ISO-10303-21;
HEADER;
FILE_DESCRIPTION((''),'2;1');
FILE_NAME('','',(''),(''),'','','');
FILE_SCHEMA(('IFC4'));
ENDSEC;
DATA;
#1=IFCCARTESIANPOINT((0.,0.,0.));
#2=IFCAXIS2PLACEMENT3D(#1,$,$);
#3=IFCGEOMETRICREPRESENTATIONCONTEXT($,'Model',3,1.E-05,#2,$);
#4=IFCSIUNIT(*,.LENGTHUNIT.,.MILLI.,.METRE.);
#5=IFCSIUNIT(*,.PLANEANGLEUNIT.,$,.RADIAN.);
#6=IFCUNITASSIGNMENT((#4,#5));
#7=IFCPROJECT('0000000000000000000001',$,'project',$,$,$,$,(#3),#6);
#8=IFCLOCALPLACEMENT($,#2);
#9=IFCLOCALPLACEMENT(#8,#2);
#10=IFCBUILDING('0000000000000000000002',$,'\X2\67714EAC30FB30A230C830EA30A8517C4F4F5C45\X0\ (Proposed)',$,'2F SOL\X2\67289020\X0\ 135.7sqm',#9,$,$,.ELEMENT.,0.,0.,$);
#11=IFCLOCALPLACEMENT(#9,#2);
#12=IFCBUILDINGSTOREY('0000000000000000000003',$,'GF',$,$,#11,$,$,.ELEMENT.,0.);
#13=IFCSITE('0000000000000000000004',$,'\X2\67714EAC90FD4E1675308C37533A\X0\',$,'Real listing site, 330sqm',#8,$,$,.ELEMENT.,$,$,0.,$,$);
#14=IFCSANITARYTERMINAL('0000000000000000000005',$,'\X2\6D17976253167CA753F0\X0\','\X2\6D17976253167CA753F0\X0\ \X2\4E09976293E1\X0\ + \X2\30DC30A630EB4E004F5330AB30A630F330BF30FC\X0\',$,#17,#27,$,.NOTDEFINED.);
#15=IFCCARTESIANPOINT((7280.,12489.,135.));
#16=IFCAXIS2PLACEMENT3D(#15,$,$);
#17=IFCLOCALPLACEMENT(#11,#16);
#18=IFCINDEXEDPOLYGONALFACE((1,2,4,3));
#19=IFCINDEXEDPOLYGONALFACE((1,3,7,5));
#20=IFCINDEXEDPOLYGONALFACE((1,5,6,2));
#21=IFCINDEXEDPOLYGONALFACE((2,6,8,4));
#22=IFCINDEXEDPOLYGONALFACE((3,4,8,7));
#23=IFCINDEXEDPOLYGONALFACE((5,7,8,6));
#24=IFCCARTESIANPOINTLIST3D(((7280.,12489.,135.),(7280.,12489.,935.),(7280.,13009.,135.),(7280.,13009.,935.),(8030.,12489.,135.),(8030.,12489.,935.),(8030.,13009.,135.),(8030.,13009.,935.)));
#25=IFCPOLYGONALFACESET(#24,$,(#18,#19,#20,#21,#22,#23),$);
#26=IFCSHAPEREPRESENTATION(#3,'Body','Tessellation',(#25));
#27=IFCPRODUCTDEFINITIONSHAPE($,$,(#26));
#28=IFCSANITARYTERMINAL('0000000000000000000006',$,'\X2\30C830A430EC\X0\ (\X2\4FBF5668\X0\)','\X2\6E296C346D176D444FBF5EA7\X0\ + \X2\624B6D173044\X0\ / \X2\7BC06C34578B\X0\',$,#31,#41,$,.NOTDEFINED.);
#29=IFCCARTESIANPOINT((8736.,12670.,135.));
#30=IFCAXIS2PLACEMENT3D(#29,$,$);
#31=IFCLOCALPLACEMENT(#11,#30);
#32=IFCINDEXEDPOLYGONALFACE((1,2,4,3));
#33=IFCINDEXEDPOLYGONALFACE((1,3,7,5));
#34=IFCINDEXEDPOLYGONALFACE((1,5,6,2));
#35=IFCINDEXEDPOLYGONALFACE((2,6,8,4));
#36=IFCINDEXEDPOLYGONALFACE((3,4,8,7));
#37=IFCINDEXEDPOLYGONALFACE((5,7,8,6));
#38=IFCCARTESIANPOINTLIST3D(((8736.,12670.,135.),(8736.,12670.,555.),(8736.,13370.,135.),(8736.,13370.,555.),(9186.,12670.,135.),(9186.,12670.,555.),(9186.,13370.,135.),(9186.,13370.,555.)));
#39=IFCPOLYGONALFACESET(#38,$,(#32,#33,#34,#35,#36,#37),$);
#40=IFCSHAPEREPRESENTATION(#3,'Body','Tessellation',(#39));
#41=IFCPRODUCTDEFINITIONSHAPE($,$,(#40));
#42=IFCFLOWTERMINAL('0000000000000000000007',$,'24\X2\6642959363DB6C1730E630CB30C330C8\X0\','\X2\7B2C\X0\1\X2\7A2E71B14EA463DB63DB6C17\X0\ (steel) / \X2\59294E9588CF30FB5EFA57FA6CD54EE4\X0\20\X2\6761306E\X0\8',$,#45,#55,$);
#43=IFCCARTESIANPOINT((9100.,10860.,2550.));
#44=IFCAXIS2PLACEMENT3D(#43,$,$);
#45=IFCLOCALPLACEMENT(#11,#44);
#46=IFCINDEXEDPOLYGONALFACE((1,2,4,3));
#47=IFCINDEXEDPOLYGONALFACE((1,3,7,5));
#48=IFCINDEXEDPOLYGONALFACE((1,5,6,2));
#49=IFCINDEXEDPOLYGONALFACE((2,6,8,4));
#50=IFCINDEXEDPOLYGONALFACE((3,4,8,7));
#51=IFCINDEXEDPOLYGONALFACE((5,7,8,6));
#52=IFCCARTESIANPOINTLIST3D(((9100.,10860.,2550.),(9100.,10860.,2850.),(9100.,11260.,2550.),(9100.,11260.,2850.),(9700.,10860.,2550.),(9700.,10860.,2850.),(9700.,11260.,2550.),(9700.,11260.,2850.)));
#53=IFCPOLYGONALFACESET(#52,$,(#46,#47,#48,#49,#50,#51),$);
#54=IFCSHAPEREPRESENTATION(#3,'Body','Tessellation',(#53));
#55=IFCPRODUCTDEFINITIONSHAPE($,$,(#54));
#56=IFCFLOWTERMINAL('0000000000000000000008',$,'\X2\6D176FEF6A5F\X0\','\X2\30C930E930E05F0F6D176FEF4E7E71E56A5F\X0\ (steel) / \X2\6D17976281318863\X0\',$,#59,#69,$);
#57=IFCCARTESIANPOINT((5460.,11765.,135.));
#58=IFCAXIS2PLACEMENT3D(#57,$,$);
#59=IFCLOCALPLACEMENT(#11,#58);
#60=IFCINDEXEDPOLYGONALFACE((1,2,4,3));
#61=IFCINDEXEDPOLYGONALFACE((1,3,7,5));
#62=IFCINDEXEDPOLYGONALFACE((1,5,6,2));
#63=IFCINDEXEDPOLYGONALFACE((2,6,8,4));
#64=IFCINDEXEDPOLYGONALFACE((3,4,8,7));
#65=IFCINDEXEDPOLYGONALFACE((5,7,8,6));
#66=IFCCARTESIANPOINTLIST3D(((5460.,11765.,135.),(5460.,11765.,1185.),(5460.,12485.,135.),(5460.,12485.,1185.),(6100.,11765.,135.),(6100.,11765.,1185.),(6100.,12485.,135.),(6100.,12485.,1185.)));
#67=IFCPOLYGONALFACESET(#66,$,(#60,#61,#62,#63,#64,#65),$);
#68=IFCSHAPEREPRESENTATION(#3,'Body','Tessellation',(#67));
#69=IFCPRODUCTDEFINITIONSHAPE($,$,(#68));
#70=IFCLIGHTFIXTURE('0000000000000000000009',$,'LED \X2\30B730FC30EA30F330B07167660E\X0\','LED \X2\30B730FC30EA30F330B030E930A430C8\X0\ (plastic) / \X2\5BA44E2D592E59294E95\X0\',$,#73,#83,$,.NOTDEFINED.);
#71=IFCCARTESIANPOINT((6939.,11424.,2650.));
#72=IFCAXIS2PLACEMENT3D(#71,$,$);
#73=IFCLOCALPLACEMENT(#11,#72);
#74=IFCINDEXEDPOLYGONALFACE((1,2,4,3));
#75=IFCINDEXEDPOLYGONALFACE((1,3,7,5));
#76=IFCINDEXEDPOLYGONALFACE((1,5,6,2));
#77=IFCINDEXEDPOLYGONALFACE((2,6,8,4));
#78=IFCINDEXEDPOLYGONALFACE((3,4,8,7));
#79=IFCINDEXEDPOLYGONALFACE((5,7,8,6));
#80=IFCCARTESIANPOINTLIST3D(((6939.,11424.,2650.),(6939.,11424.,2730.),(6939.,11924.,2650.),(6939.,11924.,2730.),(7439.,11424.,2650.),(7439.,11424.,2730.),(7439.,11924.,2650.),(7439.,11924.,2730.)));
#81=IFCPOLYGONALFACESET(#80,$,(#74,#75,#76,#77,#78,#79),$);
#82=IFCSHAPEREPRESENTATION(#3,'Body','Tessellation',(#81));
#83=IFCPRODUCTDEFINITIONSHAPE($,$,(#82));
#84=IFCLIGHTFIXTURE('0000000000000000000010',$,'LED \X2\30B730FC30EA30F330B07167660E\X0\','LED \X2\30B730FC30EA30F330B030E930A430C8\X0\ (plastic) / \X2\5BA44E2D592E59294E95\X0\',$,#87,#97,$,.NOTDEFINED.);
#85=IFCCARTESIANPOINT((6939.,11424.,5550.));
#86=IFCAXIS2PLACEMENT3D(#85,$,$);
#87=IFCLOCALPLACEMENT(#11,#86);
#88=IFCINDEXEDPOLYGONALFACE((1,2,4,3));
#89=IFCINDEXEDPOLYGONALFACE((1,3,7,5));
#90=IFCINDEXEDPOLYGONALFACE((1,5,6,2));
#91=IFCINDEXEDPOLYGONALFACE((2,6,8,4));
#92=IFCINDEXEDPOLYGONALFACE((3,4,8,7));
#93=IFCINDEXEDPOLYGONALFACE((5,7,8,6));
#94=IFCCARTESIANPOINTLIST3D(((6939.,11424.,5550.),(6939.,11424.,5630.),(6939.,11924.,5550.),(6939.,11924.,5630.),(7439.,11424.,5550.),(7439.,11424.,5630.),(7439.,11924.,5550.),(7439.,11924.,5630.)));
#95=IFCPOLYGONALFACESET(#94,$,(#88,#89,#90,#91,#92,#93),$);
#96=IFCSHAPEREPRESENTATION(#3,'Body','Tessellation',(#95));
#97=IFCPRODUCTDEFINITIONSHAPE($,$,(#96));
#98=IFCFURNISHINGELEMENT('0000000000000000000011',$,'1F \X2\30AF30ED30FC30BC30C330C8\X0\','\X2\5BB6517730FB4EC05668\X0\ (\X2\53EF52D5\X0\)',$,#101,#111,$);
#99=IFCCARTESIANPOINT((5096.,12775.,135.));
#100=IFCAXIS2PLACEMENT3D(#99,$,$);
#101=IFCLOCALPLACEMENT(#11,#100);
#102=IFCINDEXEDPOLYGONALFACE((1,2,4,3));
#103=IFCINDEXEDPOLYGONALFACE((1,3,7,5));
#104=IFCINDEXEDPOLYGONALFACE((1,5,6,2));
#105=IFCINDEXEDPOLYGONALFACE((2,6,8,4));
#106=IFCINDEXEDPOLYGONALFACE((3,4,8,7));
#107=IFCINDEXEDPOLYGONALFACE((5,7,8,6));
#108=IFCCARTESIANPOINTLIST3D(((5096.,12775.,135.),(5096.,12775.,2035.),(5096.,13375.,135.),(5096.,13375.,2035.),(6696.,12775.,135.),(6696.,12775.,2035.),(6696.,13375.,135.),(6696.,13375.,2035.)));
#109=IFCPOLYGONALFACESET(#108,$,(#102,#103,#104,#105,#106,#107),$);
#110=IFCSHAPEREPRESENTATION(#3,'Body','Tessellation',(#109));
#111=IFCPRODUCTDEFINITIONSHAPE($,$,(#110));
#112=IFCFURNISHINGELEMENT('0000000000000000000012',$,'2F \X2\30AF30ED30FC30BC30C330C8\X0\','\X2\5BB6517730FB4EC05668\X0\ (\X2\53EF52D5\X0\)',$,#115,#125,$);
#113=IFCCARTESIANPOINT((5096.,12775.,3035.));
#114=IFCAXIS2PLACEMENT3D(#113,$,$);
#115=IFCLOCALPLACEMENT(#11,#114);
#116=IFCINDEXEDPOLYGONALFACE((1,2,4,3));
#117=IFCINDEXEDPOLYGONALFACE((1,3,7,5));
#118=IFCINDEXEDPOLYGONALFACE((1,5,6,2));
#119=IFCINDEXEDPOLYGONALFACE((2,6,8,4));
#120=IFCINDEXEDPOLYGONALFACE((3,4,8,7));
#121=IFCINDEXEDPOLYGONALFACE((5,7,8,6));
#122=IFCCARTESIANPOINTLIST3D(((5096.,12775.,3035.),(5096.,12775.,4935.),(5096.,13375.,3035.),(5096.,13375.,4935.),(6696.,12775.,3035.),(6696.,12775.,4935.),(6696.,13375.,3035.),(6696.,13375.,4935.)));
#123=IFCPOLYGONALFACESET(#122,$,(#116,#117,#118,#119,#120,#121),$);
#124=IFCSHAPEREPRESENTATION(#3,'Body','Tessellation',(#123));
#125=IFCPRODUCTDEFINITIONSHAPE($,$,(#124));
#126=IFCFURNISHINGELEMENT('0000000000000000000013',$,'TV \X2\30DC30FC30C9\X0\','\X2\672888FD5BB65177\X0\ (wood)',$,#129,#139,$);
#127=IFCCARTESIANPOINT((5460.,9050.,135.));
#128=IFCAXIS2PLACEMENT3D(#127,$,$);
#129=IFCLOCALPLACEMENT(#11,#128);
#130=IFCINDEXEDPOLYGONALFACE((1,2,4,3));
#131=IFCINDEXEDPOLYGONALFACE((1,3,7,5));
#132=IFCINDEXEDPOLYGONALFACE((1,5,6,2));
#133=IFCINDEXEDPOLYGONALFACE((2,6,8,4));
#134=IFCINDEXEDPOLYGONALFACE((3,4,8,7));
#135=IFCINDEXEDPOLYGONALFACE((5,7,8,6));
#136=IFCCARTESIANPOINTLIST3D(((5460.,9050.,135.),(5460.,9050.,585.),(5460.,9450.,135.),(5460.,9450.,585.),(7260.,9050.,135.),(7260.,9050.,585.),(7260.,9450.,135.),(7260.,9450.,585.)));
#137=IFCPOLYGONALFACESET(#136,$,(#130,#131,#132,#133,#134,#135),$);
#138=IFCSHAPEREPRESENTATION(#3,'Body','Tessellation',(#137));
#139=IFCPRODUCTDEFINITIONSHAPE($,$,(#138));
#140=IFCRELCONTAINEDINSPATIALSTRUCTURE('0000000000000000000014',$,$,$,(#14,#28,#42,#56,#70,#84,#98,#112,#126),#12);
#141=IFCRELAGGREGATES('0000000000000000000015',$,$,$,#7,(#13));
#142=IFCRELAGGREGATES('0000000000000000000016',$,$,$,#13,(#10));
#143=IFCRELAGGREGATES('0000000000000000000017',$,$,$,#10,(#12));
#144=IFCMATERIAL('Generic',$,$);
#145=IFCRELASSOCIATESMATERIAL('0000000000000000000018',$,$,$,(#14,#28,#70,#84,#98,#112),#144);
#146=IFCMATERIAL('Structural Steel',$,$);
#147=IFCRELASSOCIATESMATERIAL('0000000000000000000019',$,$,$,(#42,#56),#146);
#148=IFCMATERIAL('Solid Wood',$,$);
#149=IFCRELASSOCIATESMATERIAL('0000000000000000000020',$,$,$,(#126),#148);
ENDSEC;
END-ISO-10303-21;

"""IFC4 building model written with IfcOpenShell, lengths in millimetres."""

from ifc_helpers import new_model, si_unit, frame, frame_2d, origin, place, context, project, spatial, rectangle, extrude, material, element, save


model = new_model("IFC4")

# Units and contexts
model_context = context("Model", 3, precision=1e-05, world=origin())
ifc_project = project(units=[si_unit("LENGTHUNIT", "METRE", prefix="MILLI"), si_unit("PLANEANGLEUNIT", "RADIAN")], contexts=[model_context])

# Site, building, storey
site_placement = place(None, origin())
site = spatial("IfcSite", under=ifc_project, at=site_placement, Name="東京都世田谷区", ObjectType="Real listing site, 330sqm", CompositionType="ELEMENT", RefElevation=0.0)
building_placement = place(site_placement, origin())
building = spatial("IfcBuilding", under=site, at=building_placement, Name="東京・アトリエ兼住居 (Proposed)", ObjectType="2F SOL木造 135.7sqm", CompositionType="ELEMENT", ElevationOfRefHeight=0.0, ElevationOfTerrain=0.0)
storey_placement = place(building_placement, origin())
storey = spatial("IfcBuildingStorey", under=building, at=storey_placement, Name="GF", CompositionType="ELEMENT", Elevation=0.0)

# Shared definitions
ifc_material_1 = material(Name="Solid Wood")

# Sanitary terminals
ifc_material_2 = material(Name="Generic")
sanitary_terminal_1_placement = place(storey_placement, frame((7280.0, 12489.0, 135.0)))
element("IfcSanitaryTerminal", 1, at=sanitary_terminal_1_placement, inside=storey, material=ifc_material_2, Name="洗面化粧台", Description="洗面化粧台 三面鏡 + ボウル一体カウンター", PredefinedType="NOTDEFINED", context=model_context, shape_type="SweptSolid", body=[
    extrude(rectangle(XDim=750.0, YDim=520.0, at=frame_2d((375.0, 260.0))), frame((7280.0, 12489.0, 135.0)), (0.0, 0.0, 1.0), 800.0),
])
sanitary_terminal_2_placement = place(storey_placement, frame((8736.0, 12670.0, 135.0)))
element("IfcSanitaryTerminal", 2, at=sanitary_terminal_2_placement, inside=storey, material=ifc_material_2, Name="トイレ (便器)", Description="温水洗浄便座 + 手洗い / 節水型", PredefinedType="NOTDEFINED", context=model_context, shape_type="SweptSolid", body=[
    extrude(rectangle(XDim=450.0, YDim=700.0, at=frame_2d((225.0, 350.0))), frame((8736.0, 12670.0, 135.0)), (0.0, 0.0, 1.0), 420.0),
])

# Flow terminals
ifc_material_3 = material(Name="Structural Steel")
flow_terminal_1_placement = place(storey_placement, frame((9100.0, 10860.0, 2550.0)))
element("IfcFlowTerminal", 3, at=flow_terminal_1_placement, inside=storey, material=ifc_material_3, Name="24時間換気ユニット", Description="第1種熱交換換気 (steel) / 天井裏・建基法令20条の8", context=model_context, shape_type="SweptSolid", body=[
    extrude(rectangle(XDim=600.0, YDim=400.0, at=frame_2d((300.0, 200.0))), frame((9100.0, 10860.0, 2550.0)), (0.0, 0.0, 1.0), 300.0),
])
flow_terminal_2_placement = place(storey_placement, frame((5460.0, 11765.0, 135.0)))
element("IfcFlowTerminal", 4, at=flow_terminal_2_placement, inside=storey, material=ifc_material_3, Name="洗濯機", Description="ドラム式洗濯乾燥機 (steel) / 洗面脱衣", context=model_context, shape_type="SweptSolid", body=[
    extrude(rectangle(XDim=640.0, YDim=720.0, at=frame_2d((320.0, 360.0))), frame((5460.0, 11765.0, 135.0)), (0.0, 0.0, 1.0), 1050.0),
])

# Light fixtures
light_fixture_1_placement = place(storey_placement, frame((6939.0, 11424.0, 2650.0)))
element("IfcLightFixture", 5, at=light_fixture_1_placement, inside=storey, material=ifc_material_2, Name="LED シーリング照明", Description="LED シーリングライト (plastic) / 室中央天井", PredefinedType="NOTDEFINED", context=model_context, shape_type="SweptSolid", body=[
    extrude(rectangle(XDim=500.0, YDim=500.0, at=frame_2d((250.0, 250.0))), frame((6939.0, 11424.0, 2650.0)), (0.0, 0.0, 1.0), 80.0),
])
light_fixture_2_placement = place(storey_placement, frame((6939.0, 11424.0, 5550.0)))
element("IfcLightFixture", 6, at=light_fixture_2_placement, inside=storey, material=ifc_material_2, Name="LED シーリング照明", Description="LED シーリングライト (plastic) / 室中央天井", PredefinedType="NOTDEFINED", context=model_context, shape_type="SweptSolid", body=[
    extrude(rectangle(XDim=500.0, YDim=500.0, at=frame_2d((250.0, 250.0))), frame((6939.0, 11424.0, 5550.0)), (0.0, 0.0, 1.0), 80.0),
])

# Furnishing elements
furnishing_1_placement = place(storey_placement, frame((5096.0, 12775.0, 135.0)))
element("IfcFurnishingElement", 7, at=furnishing_1_placement, inside=storey, material=ifc_material_2, Name="1F クローゼット", Description="家具・什器 (可動)", context=model_context, shape_type="SweptSolid", body=[
    extrude(rectangle(XDim=1600.0, YDim=600.0, at=frame_2d((800.0, 300.0))), frame((5096.0, 12775.0, 135.0)), (0.0, 0.0, 1.0), 1900.0),
])
furnishing_2_placement = place(storey_placement, frame((5096.0, 12775.0, 3035.0)))
element("IfcFurnishingElement", 8, at=furnishing_2_placement, inside=storey, material=ifc_material_2, Name="2F クローゼット", Description="家具・什器 (可動)", context=model_context, shape_type="SweptSolid", body=[
    extrude(rectangle(XDim=1600.0, YDim=600.0, at=frame_2d((800.0, 300.0))), frame((5096.0, 12775.0, 3035.0)), (0.0, 0.0, 1.0), 1900.0),
])
furnishing_3_placement = place(storey_placement, frame((5460.0, 9050.0, 135.0)))
element("IfcFurnishingElement", 9, at=furnishing_3_placement, inside=storey, material=ifc_material_1, Name="TV ボード", Description="木製家具 (wood)", context=model_context, shape_type="SweptSolid", body=[
    extrude(rectangle(XDim=1800.0, YDim=400.0, at=frame_2d((900.0, 200.0))), frame((5460.0, 9050.0, 135.0)), (0.0, 0.0, 1.0), 450.0),
])

save(model, "model.ifc")
